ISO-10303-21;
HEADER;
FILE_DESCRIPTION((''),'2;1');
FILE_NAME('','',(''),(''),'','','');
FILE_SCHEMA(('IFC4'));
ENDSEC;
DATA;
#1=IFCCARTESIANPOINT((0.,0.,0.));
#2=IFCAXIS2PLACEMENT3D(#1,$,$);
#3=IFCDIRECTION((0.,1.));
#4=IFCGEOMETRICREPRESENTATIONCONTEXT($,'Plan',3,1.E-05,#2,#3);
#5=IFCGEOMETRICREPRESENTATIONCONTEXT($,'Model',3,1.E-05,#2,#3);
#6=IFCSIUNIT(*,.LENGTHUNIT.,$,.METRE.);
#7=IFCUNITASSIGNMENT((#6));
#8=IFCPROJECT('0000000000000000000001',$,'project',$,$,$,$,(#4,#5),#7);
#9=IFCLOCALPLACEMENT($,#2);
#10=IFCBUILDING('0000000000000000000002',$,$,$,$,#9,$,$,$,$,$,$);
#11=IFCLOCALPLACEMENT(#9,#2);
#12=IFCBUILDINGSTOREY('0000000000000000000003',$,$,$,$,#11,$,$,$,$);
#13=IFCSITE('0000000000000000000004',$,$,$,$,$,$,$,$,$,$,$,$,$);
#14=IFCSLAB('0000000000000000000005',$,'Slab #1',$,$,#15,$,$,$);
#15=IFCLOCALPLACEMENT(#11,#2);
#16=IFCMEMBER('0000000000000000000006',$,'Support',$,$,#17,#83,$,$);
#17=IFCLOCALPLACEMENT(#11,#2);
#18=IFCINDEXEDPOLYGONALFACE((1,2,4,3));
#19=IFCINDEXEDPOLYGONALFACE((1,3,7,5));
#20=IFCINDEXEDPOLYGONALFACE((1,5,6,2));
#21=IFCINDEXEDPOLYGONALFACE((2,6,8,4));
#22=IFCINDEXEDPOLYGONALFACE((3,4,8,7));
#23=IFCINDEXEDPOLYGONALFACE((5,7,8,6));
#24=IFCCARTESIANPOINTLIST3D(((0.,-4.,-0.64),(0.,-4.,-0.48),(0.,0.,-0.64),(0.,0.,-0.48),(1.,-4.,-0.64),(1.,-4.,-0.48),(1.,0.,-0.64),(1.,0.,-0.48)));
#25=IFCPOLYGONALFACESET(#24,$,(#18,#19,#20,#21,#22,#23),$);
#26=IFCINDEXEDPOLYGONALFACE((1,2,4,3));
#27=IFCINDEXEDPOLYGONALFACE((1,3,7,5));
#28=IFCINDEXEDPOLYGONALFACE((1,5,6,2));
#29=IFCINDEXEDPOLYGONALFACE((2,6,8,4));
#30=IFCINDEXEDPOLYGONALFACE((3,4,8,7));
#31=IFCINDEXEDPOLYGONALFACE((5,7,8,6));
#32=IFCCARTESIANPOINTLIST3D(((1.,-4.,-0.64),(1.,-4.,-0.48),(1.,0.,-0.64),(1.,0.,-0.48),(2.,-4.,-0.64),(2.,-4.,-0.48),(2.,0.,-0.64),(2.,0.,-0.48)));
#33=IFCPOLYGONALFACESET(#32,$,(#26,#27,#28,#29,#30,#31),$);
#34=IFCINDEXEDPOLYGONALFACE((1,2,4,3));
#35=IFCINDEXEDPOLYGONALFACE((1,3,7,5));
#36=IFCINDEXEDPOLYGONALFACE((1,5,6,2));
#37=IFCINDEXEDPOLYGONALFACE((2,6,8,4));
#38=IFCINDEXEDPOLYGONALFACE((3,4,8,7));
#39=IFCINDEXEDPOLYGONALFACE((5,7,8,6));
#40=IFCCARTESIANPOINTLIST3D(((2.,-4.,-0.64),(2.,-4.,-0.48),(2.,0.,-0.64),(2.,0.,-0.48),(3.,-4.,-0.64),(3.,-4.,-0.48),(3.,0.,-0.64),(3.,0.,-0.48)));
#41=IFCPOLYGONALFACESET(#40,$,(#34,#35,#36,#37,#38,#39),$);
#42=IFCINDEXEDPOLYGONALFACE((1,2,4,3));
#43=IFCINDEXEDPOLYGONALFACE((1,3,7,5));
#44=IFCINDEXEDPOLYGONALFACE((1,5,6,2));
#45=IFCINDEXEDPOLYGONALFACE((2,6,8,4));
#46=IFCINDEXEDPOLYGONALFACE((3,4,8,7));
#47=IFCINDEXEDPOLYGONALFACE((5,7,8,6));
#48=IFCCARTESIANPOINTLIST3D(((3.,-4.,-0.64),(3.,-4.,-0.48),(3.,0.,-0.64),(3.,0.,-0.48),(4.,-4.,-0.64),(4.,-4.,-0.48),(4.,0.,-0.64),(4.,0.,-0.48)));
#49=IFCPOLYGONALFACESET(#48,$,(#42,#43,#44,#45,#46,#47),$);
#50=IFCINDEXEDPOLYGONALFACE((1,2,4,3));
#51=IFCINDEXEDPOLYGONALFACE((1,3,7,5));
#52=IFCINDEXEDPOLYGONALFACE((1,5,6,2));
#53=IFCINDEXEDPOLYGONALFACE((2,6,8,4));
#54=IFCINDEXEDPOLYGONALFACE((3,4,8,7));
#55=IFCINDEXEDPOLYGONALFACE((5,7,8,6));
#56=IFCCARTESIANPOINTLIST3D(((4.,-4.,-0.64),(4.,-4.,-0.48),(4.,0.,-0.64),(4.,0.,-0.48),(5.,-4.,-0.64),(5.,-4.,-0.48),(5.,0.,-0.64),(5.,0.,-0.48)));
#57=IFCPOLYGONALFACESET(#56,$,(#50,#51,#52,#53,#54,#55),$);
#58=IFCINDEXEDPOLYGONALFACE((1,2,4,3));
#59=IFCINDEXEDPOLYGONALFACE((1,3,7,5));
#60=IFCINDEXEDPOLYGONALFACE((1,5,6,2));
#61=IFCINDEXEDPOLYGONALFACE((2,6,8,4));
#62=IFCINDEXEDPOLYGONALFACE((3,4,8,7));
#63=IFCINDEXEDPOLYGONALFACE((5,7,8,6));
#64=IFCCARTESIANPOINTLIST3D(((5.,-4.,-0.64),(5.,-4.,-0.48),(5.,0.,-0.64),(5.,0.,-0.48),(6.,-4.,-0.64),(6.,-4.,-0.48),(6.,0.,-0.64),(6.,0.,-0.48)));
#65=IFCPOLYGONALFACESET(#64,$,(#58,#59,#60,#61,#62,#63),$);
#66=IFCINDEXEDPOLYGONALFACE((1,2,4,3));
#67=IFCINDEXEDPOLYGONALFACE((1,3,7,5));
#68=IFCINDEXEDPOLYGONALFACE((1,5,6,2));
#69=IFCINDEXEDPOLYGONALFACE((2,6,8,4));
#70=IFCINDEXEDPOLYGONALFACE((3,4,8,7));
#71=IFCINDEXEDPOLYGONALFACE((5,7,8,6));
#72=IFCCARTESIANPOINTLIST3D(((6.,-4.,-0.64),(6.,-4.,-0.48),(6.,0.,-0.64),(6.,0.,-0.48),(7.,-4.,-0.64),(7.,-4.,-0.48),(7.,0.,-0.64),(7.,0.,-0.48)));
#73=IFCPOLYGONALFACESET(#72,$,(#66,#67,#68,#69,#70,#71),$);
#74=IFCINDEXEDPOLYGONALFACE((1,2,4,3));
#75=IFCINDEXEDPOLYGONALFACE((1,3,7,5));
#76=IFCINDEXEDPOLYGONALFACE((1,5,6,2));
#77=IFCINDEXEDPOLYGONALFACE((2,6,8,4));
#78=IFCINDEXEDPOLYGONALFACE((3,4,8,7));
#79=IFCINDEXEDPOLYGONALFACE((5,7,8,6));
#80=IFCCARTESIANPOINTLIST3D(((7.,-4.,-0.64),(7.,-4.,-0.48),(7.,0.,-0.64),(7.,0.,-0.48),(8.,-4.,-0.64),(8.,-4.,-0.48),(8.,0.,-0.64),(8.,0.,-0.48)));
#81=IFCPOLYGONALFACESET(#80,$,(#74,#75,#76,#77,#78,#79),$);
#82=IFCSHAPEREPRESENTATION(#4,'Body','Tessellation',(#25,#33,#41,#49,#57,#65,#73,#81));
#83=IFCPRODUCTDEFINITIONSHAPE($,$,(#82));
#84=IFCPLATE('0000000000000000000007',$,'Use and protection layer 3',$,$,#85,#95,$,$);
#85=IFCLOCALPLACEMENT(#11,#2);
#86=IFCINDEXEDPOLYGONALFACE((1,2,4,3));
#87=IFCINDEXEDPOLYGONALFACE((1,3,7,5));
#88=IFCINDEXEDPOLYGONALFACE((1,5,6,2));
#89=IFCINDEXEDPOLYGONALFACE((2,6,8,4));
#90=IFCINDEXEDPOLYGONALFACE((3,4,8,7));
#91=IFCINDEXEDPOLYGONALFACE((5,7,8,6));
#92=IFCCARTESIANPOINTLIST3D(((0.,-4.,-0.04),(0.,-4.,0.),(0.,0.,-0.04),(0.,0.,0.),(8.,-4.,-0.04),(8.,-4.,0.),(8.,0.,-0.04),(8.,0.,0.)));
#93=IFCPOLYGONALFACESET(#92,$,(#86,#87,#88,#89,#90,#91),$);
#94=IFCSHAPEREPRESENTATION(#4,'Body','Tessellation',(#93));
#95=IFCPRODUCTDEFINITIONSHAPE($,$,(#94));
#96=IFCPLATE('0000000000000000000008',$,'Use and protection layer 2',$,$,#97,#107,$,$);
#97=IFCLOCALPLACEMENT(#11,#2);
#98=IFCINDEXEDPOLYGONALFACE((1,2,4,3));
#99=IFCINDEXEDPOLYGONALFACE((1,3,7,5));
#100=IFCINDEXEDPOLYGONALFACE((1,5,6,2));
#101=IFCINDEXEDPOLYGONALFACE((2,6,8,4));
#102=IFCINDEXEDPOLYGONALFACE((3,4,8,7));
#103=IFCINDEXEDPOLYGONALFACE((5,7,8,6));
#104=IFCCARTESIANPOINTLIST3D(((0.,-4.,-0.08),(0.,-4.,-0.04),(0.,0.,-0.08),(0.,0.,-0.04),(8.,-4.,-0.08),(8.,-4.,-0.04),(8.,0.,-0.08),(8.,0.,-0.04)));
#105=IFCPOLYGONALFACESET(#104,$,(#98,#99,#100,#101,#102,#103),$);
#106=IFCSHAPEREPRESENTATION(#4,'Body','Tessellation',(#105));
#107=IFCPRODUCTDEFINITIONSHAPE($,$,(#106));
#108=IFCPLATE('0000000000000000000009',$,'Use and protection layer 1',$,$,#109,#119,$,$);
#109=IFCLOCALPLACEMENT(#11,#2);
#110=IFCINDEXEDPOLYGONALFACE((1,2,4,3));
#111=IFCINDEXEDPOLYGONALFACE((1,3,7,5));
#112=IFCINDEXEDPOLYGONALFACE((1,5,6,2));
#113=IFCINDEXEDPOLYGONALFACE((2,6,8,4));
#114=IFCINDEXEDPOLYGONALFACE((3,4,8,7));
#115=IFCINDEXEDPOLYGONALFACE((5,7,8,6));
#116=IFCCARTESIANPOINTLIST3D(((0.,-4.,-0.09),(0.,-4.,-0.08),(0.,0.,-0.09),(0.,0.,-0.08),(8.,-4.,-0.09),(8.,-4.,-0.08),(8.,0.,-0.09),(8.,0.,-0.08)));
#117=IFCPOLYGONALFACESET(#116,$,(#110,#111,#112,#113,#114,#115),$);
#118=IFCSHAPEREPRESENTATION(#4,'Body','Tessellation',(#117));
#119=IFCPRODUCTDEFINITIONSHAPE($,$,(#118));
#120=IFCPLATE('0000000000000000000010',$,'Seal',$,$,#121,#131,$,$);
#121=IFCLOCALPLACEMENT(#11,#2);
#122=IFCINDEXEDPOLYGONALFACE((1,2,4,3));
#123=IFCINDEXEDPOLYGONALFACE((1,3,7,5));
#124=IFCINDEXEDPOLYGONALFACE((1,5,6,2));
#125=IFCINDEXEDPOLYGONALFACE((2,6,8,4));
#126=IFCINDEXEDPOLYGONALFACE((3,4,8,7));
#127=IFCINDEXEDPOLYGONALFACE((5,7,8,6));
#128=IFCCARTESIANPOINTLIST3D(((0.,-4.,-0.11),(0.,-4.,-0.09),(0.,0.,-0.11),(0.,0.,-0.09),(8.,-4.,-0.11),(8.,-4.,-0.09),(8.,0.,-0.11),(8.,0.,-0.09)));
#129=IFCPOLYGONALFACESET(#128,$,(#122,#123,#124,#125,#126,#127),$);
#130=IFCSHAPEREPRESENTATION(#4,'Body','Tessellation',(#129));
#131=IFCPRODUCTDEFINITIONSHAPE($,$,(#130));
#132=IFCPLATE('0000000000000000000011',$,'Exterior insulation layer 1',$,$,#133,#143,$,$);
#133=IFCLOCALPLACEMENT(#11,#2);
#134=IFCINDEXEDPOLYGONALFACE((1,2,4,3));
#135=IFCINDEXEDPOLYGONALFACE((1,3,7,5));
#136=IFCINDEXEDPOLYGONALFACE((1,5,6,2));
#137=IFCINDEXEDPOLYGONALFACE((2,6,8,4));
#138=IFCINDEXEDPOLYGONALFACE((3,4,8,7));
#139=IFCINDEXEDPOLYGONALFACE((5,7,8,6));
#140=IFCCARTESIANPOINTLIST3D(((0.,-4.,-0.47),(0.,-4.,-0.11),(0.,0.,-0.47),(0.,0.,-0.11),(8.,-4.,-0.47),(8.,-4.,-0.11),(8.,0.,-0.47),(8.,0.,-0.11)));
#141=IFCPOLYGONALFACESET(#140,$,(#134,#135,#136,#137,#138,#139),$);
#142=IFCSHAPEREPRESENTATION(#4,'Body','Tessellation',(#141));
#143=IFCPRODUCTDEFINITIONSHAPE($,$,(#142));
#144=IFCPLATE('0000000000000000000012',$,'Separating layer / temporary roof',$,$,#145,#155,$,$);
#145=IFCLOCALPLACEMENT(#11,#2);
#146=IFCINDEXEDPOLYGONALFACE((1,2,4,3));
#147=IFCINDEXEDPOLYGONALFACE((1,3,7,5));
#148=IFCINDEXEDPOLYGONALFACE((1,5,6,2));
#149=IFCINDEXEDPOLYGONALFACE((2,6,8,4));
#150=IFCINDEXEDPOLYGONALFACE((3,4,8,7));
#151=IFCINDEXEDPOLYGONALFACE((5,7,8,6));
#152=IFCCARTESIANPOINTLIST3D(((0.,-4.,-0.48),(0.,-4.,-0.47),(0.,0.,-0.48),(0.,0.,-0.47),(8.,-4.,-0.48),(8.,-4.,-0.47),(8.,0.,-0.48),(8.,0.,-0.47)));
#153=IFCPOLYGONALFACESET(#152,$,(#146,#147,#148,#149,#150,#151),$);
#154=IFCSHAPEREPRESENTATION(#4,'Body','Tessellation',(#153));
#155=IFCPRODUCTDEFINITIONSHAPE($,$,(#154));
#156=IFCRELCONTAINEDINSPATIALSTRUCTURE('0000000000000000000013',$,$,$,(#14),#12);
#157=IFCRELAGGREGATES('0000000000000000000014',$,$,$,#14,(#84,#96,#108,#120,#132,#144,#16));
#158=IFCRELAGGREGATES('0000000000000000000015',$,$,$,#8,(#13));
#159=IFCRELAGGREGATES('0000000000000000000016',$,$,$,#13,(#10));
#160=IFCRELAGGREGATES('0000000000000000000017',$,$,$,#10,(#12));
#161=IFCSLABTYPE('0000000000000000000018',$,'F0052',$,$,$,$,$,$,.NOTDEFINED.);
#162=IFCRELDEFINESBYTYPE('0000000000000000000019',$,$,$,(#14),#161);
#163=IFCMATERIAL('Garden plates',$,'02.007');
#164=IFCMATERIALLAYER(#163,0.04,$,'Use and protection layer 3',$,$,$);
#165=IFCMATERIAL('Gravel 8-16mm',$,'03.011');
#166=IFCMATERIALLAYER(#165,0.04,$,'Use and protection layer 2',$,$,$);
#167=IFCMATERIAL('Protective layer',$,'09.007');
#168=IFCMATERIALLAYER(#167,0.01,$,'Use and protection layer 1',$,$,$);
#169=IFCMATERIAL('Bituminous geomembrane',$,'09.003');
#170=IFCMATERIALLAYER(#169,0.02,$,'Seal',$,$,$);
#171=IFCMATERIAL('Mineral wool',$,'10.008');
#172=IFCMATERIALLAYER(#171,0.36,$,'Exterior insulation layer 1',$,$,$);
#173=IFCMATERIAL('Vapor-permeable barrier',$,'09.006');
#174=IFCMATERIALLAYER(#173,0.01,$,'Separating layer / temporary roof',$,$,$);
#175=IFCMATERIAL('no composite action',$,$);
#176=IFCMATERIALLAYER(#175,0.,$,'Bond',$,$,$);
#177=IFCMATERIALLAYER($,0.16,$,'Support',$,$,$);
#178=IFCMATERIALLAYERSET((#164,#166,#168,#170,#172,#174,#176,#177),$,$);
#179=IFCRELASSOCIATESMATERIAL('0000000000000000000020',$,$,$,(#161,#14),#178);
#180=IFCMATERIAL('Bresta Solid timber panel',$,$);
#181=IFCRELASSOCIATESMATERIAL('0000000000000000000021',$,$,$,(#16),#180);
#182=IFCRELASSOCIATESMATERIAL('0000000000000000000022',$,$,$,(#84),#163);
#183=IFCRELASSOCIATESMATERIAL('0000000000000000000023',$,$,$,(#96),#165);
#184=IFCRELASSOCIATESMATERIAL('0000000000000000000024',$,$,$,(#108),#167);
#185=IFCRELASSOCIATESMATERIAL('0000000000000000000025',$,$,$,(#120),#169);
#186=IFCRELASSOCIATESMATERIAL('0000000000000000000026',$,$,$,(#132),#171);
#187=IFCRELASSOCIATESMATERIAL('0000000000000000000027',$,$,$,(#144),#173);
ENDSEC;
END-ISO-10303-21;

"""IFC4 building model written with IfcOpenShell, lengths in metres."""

from ifc_helpers import new_model, si_unit, direction, frame, frame_2d, origin, origin_with_axes, place, context, project, spatial, rectangle, extrude, material, layer, layer_set, type_object, element, aggregate, save


model = new_model("IFC4")

# Units and contexts
plan_context = context("Plan", 3, precision=1e-05, world=origin(), true_north=direction((0.0, 1.0)))
model_context = context("Model", 3, precision=1e-05, world=origin(), true_north=direction((0.0, 1.0)))
ifc_project = project(units=[si_unit("LENGTHUNIT", "METRE")], contexts=[plan_context, model_context])

# Site, building, storey
site = spatial("IfcSite", under=ifc_project)
building_placement = place(None, origin())
building = spatial("IfcBuilding", under=site, at=building_placement)
storey_placement = place(building_placement, origin())
storey = spatial("IfcBuildingStorey", under=building, at=storey_placement)

# Slab, member, plates
ifc_material_1 = material(Name="Garden plates", Category="02.007")
ifc_layer_1 = layer(ifc_material_1, 0.04, Name="Use and protection layer 3")
ifc_material_2 = material(Name="Gravel 8-16mm", Category="03.011")
ifc_layer_2 = layer(ifc_material_2, 0.04, Name="Use and protection layer 2")
ifc_material_3 = material(Name="Protective layer", Category="09.007")
ifc_layer_3 = layer(ifc_material_3, 0.01, Name="Use and protection layer 1")
ifc_material_4 = material(Name="Bituminous geomembrane", Category="09.003")
ifc_layer_4 = layer(ifc_material_4, 0.02, Name="Seal")
ifc_material_5 = material(Name="Mineral wool", Category="10.008")
ifc_layer_5 = layer(ifc_material_5, 0.36, Name="Exterior insulation layer 1")
ifc_material_6 = material(Name="Vapor-permeable barrier", Category="09.006")
ifc_layer_6 = layer(ifc_material_6, 0.01, Name="Separating layer / temporary roof")
ifc_material_7 = material(Name="no composite action")
ifc_layer_7 = layer(ifc_material_7, 0.0, Name="Bond")
ifc_layer_8 = layer(None, 0.16, Name="Support")
ifc_layer_set = layer_set([ifc_layer_1, ifc_layer_2, ifc_layer_3, ifc_layer_4, ifc_layer_5, ifc_layer_6, ifc_layer_7, ifc_layer_8])
slab_type = type_object("IfcSlabType", Name="F0052", PredefinedType="NOTDEFINED", material=ifc_layer_set)
slab_placement = place(None, frame((0.0, 0.0, 0.0), z_axis=(0.0, 0.0, -1.0), x_axis=(1.0, 0.0, 0.0)))
slab = element("IfcSlab", 1, at=slab_placement, inside=storey, type_object=slab_type, material=ifc_layer_set, Name="Slab #1")
ifc_material_8 = material(Name="Bresta Solid timber panel")
member_placement = place(slab_placement, origin())
member = element("IfcMember", 2, at=member_placement, material=ifc_material_8, Name="Support", context=plan_context, shape_type="SweptSolid", body=[
    extrude(rectangle(XDim=1.0, YDim=0.16, at=frame_2d((0.5, 0.08), x_axis=(1.0, 0.0))), frame((0.0, 4.0, 0.48), z_axis=(0.0, -1.0, 0.0), x_axis=(1.0, 0.0, 0.0)), (0.0, 0.0, 1.0), 4.0),
    extrude(rectangle(XDim=1.0, YDim=0.16, at=frame_2d((0.5, 0.08), x_axis=(1.0, 0.0))), frame((1.0, 4.0, 0.48), z_axis=(0.0, -1.0, 0.0), x_axis=(1.0, 0.0, 0.0)), (0.0, 0.0, 1.0), 4.0),
    extrude(rectangle(XDim=1.0, YDim=0.16, at=frame_2d((0.5, 0.08), x_axis=(1.0, 0.0))), frame((2.0, 4.0, 0.48), z_axis=(0.0, -1.0, 0.0), x_axis=(1.0, 0.0, 0.0)), (0.0, 0.0, 1.0), 4.0),
    extrude(rectangle(XDim=1.0, YDim=0.16, at=frame_2d((0.5, 0.08), x_axis=(1.0, 0.0))), frame((3.0, 4.0, 0.48), z_axis=(0.0, -1.0, 0.0), x_axis=(1.0, 0.0, 0.0)), (0.0, 0.0, 1.0), 4.0),
    extrude(rectangle(XDim=1.0, YDim=0.16, at=frame_2d((0.5, 0.08), x_axis=(1.0, 0.0))), frame((4.0, 4.0, 0.48), z_axis=(0.0, -1.0, 0.0), x_axis=(1.0, 0.0, 0.0)), (0.0, 0.0, 1.0), 4.0),
    extrude(rectangle(XDim=1.0, YDim=0.16, at=frame_2d((0.5, 0.08), x_axis=(1.0, 0.0))), frame((5.0, 4.0, 0.48), z_axis=(0.0, -1.0, 0.0), x_axis=(1.0, 0.0, 0.0)), (0.0, 0.0, 1.0), 4.0),
    extrude(rectangle(XDim=1.0, YDim=0.16, at=frame_2d((0.5, 0.08), x_axis=(1.0, 0.0))), frame((6.0, 4.0, 0.48), z_axis=(0.0, -1.0, 0.0), x_axis=(1.0, 0.0, 0.0)), (0.0, 0.0, 1.0), 4.0),
    extrude(rectangle(XDim=1.0, YDim=0.16, at=frame_2d((0.5, 0.08), x_axis=(1.0, 0.0))), frame((7.0, 4.0, 0.48), z_axis=(0.0, -1.0, 0.0), x_axis=(1.0, 0.0, 0.0)), (0.0, 0.0, 1.0), 4.0),
])
plate_1_placement = place(slab_placement, origin())
plate_1 = element("IfcPlate", 3, at=plate_1_placement, material=ifc_material_1, Name="Use and protection layer 3", context=plan_context, shape_type="SweptSolid", body=[
    extrude(rectangle(XDim=8.0, YDim=4.0, at=frame_2d((4.0, 2.0), x_axis=(1.0, 0.0))), origin_with_axes(), (0.0, 0.0, 1.0), 0.04),
])
plate_2_placement = place(slab_placement, origin())
plate_2 = element("IfcPlate", 4, at=plate_2_placement, material=ifc_material_2, Name="Use and protection layer 2", context=plan_context, shape_type="SweptSolid", body=[
    extrude(rectangle(XDim=8.0, YDim=4.0, at=frame_2d((4.0, 2.0), x_axis=(1.0, 0.0))), frame((0.0, 0.0, 0.04), z_axis=(0.0, 0.0, 1.0), x_axis=(1.0, 0.0, 0.0)), (0.0, 0.0, 1.0), 0.04),
])
plate_3_placement = place(slab_placement, origin())
plate_3 = element("IfcPlate", 5, at=plate_3_placement, material=ifc_material_3, Name="Use and protection layer 1", context=plan_context, shape_type="SweptSolid", body=[
    extrude(rectangle(XDim=8.0, YDim=4.0, at=frame_2d((4.0, 2.0), x_axis=(1.0, 0.0))), frame((0.0, 0.0, 0.08), z_axis=(0.0, 0.0, 1.0), x_axis=(1.0, 0.0, 0.0)), (0.0, 0.0, 1.0), 0.01),
])
plate_4_placement = place(slab_placement, origin())
plate_4 = element("IfcPlate", 6, at=plate_4_placement, material=ifc_material_4, Name="Seal", context=plan_context, shape_type="SweptSolid", body=[
    extrude(rectangle(XDim=8.0, YDim=4.0, at=frame_2d((4.0, 2.0), x_axis=(1.0, 0.0))), frame((0.0, 0.0, 0.09), z_axis=(0.0, 0.0, 1.0), x_axis=(1.0, 0.0, 0.0)), (0.0, 0.0, 1.0), 0.02),
])
plate_5_placement = place(slab_placement, origin())
plate_5 = element("IfcPlate", 7, at=plate_5_placement, material=ifc_material_5, Name="Exterior insulation layer 1", context=plan_context, shape_type="SweptSolid", body=[
    extrude(rectangle(XDim=8.0, YDim=4.0, at=frame_2d((4.0, 2.0), x_axis=(1.0, 0.0))), frame((0.0, 0.0, 0.11), z_axis=(0.0, 0.0, 1.0), x_axis=(1.0, 0.0, 0.0)), (0.0, 0.0, 1.0), 0.36),
])
plate_6_placement = place(slab_placement, origin())
plate_6 = element("IfcPlate", 8, at=plate_6_placement, material=ifc_material_6, Name="Separating layer / temporary roof", context=plan_context, shape_type="SweptSolid", body=[
    extrude(rectangle(XDim=8.0, YDim=4.0, at=frame_2d((4.0, 2.0), x_axis=(1.0, 0.0))), frame((0.0, 0.0, 0.47), z_axis=(0.0, 0.0, 1.0), x_axis=(1.0, 0.0, 0.0)), (0.0, 0.0, 1.0), 0.01),
])
aggregate(slab, [plate_1, plate_2, plate_3, plate_4, plate_5, plate_6, member])

save(model, "model.ifc")
